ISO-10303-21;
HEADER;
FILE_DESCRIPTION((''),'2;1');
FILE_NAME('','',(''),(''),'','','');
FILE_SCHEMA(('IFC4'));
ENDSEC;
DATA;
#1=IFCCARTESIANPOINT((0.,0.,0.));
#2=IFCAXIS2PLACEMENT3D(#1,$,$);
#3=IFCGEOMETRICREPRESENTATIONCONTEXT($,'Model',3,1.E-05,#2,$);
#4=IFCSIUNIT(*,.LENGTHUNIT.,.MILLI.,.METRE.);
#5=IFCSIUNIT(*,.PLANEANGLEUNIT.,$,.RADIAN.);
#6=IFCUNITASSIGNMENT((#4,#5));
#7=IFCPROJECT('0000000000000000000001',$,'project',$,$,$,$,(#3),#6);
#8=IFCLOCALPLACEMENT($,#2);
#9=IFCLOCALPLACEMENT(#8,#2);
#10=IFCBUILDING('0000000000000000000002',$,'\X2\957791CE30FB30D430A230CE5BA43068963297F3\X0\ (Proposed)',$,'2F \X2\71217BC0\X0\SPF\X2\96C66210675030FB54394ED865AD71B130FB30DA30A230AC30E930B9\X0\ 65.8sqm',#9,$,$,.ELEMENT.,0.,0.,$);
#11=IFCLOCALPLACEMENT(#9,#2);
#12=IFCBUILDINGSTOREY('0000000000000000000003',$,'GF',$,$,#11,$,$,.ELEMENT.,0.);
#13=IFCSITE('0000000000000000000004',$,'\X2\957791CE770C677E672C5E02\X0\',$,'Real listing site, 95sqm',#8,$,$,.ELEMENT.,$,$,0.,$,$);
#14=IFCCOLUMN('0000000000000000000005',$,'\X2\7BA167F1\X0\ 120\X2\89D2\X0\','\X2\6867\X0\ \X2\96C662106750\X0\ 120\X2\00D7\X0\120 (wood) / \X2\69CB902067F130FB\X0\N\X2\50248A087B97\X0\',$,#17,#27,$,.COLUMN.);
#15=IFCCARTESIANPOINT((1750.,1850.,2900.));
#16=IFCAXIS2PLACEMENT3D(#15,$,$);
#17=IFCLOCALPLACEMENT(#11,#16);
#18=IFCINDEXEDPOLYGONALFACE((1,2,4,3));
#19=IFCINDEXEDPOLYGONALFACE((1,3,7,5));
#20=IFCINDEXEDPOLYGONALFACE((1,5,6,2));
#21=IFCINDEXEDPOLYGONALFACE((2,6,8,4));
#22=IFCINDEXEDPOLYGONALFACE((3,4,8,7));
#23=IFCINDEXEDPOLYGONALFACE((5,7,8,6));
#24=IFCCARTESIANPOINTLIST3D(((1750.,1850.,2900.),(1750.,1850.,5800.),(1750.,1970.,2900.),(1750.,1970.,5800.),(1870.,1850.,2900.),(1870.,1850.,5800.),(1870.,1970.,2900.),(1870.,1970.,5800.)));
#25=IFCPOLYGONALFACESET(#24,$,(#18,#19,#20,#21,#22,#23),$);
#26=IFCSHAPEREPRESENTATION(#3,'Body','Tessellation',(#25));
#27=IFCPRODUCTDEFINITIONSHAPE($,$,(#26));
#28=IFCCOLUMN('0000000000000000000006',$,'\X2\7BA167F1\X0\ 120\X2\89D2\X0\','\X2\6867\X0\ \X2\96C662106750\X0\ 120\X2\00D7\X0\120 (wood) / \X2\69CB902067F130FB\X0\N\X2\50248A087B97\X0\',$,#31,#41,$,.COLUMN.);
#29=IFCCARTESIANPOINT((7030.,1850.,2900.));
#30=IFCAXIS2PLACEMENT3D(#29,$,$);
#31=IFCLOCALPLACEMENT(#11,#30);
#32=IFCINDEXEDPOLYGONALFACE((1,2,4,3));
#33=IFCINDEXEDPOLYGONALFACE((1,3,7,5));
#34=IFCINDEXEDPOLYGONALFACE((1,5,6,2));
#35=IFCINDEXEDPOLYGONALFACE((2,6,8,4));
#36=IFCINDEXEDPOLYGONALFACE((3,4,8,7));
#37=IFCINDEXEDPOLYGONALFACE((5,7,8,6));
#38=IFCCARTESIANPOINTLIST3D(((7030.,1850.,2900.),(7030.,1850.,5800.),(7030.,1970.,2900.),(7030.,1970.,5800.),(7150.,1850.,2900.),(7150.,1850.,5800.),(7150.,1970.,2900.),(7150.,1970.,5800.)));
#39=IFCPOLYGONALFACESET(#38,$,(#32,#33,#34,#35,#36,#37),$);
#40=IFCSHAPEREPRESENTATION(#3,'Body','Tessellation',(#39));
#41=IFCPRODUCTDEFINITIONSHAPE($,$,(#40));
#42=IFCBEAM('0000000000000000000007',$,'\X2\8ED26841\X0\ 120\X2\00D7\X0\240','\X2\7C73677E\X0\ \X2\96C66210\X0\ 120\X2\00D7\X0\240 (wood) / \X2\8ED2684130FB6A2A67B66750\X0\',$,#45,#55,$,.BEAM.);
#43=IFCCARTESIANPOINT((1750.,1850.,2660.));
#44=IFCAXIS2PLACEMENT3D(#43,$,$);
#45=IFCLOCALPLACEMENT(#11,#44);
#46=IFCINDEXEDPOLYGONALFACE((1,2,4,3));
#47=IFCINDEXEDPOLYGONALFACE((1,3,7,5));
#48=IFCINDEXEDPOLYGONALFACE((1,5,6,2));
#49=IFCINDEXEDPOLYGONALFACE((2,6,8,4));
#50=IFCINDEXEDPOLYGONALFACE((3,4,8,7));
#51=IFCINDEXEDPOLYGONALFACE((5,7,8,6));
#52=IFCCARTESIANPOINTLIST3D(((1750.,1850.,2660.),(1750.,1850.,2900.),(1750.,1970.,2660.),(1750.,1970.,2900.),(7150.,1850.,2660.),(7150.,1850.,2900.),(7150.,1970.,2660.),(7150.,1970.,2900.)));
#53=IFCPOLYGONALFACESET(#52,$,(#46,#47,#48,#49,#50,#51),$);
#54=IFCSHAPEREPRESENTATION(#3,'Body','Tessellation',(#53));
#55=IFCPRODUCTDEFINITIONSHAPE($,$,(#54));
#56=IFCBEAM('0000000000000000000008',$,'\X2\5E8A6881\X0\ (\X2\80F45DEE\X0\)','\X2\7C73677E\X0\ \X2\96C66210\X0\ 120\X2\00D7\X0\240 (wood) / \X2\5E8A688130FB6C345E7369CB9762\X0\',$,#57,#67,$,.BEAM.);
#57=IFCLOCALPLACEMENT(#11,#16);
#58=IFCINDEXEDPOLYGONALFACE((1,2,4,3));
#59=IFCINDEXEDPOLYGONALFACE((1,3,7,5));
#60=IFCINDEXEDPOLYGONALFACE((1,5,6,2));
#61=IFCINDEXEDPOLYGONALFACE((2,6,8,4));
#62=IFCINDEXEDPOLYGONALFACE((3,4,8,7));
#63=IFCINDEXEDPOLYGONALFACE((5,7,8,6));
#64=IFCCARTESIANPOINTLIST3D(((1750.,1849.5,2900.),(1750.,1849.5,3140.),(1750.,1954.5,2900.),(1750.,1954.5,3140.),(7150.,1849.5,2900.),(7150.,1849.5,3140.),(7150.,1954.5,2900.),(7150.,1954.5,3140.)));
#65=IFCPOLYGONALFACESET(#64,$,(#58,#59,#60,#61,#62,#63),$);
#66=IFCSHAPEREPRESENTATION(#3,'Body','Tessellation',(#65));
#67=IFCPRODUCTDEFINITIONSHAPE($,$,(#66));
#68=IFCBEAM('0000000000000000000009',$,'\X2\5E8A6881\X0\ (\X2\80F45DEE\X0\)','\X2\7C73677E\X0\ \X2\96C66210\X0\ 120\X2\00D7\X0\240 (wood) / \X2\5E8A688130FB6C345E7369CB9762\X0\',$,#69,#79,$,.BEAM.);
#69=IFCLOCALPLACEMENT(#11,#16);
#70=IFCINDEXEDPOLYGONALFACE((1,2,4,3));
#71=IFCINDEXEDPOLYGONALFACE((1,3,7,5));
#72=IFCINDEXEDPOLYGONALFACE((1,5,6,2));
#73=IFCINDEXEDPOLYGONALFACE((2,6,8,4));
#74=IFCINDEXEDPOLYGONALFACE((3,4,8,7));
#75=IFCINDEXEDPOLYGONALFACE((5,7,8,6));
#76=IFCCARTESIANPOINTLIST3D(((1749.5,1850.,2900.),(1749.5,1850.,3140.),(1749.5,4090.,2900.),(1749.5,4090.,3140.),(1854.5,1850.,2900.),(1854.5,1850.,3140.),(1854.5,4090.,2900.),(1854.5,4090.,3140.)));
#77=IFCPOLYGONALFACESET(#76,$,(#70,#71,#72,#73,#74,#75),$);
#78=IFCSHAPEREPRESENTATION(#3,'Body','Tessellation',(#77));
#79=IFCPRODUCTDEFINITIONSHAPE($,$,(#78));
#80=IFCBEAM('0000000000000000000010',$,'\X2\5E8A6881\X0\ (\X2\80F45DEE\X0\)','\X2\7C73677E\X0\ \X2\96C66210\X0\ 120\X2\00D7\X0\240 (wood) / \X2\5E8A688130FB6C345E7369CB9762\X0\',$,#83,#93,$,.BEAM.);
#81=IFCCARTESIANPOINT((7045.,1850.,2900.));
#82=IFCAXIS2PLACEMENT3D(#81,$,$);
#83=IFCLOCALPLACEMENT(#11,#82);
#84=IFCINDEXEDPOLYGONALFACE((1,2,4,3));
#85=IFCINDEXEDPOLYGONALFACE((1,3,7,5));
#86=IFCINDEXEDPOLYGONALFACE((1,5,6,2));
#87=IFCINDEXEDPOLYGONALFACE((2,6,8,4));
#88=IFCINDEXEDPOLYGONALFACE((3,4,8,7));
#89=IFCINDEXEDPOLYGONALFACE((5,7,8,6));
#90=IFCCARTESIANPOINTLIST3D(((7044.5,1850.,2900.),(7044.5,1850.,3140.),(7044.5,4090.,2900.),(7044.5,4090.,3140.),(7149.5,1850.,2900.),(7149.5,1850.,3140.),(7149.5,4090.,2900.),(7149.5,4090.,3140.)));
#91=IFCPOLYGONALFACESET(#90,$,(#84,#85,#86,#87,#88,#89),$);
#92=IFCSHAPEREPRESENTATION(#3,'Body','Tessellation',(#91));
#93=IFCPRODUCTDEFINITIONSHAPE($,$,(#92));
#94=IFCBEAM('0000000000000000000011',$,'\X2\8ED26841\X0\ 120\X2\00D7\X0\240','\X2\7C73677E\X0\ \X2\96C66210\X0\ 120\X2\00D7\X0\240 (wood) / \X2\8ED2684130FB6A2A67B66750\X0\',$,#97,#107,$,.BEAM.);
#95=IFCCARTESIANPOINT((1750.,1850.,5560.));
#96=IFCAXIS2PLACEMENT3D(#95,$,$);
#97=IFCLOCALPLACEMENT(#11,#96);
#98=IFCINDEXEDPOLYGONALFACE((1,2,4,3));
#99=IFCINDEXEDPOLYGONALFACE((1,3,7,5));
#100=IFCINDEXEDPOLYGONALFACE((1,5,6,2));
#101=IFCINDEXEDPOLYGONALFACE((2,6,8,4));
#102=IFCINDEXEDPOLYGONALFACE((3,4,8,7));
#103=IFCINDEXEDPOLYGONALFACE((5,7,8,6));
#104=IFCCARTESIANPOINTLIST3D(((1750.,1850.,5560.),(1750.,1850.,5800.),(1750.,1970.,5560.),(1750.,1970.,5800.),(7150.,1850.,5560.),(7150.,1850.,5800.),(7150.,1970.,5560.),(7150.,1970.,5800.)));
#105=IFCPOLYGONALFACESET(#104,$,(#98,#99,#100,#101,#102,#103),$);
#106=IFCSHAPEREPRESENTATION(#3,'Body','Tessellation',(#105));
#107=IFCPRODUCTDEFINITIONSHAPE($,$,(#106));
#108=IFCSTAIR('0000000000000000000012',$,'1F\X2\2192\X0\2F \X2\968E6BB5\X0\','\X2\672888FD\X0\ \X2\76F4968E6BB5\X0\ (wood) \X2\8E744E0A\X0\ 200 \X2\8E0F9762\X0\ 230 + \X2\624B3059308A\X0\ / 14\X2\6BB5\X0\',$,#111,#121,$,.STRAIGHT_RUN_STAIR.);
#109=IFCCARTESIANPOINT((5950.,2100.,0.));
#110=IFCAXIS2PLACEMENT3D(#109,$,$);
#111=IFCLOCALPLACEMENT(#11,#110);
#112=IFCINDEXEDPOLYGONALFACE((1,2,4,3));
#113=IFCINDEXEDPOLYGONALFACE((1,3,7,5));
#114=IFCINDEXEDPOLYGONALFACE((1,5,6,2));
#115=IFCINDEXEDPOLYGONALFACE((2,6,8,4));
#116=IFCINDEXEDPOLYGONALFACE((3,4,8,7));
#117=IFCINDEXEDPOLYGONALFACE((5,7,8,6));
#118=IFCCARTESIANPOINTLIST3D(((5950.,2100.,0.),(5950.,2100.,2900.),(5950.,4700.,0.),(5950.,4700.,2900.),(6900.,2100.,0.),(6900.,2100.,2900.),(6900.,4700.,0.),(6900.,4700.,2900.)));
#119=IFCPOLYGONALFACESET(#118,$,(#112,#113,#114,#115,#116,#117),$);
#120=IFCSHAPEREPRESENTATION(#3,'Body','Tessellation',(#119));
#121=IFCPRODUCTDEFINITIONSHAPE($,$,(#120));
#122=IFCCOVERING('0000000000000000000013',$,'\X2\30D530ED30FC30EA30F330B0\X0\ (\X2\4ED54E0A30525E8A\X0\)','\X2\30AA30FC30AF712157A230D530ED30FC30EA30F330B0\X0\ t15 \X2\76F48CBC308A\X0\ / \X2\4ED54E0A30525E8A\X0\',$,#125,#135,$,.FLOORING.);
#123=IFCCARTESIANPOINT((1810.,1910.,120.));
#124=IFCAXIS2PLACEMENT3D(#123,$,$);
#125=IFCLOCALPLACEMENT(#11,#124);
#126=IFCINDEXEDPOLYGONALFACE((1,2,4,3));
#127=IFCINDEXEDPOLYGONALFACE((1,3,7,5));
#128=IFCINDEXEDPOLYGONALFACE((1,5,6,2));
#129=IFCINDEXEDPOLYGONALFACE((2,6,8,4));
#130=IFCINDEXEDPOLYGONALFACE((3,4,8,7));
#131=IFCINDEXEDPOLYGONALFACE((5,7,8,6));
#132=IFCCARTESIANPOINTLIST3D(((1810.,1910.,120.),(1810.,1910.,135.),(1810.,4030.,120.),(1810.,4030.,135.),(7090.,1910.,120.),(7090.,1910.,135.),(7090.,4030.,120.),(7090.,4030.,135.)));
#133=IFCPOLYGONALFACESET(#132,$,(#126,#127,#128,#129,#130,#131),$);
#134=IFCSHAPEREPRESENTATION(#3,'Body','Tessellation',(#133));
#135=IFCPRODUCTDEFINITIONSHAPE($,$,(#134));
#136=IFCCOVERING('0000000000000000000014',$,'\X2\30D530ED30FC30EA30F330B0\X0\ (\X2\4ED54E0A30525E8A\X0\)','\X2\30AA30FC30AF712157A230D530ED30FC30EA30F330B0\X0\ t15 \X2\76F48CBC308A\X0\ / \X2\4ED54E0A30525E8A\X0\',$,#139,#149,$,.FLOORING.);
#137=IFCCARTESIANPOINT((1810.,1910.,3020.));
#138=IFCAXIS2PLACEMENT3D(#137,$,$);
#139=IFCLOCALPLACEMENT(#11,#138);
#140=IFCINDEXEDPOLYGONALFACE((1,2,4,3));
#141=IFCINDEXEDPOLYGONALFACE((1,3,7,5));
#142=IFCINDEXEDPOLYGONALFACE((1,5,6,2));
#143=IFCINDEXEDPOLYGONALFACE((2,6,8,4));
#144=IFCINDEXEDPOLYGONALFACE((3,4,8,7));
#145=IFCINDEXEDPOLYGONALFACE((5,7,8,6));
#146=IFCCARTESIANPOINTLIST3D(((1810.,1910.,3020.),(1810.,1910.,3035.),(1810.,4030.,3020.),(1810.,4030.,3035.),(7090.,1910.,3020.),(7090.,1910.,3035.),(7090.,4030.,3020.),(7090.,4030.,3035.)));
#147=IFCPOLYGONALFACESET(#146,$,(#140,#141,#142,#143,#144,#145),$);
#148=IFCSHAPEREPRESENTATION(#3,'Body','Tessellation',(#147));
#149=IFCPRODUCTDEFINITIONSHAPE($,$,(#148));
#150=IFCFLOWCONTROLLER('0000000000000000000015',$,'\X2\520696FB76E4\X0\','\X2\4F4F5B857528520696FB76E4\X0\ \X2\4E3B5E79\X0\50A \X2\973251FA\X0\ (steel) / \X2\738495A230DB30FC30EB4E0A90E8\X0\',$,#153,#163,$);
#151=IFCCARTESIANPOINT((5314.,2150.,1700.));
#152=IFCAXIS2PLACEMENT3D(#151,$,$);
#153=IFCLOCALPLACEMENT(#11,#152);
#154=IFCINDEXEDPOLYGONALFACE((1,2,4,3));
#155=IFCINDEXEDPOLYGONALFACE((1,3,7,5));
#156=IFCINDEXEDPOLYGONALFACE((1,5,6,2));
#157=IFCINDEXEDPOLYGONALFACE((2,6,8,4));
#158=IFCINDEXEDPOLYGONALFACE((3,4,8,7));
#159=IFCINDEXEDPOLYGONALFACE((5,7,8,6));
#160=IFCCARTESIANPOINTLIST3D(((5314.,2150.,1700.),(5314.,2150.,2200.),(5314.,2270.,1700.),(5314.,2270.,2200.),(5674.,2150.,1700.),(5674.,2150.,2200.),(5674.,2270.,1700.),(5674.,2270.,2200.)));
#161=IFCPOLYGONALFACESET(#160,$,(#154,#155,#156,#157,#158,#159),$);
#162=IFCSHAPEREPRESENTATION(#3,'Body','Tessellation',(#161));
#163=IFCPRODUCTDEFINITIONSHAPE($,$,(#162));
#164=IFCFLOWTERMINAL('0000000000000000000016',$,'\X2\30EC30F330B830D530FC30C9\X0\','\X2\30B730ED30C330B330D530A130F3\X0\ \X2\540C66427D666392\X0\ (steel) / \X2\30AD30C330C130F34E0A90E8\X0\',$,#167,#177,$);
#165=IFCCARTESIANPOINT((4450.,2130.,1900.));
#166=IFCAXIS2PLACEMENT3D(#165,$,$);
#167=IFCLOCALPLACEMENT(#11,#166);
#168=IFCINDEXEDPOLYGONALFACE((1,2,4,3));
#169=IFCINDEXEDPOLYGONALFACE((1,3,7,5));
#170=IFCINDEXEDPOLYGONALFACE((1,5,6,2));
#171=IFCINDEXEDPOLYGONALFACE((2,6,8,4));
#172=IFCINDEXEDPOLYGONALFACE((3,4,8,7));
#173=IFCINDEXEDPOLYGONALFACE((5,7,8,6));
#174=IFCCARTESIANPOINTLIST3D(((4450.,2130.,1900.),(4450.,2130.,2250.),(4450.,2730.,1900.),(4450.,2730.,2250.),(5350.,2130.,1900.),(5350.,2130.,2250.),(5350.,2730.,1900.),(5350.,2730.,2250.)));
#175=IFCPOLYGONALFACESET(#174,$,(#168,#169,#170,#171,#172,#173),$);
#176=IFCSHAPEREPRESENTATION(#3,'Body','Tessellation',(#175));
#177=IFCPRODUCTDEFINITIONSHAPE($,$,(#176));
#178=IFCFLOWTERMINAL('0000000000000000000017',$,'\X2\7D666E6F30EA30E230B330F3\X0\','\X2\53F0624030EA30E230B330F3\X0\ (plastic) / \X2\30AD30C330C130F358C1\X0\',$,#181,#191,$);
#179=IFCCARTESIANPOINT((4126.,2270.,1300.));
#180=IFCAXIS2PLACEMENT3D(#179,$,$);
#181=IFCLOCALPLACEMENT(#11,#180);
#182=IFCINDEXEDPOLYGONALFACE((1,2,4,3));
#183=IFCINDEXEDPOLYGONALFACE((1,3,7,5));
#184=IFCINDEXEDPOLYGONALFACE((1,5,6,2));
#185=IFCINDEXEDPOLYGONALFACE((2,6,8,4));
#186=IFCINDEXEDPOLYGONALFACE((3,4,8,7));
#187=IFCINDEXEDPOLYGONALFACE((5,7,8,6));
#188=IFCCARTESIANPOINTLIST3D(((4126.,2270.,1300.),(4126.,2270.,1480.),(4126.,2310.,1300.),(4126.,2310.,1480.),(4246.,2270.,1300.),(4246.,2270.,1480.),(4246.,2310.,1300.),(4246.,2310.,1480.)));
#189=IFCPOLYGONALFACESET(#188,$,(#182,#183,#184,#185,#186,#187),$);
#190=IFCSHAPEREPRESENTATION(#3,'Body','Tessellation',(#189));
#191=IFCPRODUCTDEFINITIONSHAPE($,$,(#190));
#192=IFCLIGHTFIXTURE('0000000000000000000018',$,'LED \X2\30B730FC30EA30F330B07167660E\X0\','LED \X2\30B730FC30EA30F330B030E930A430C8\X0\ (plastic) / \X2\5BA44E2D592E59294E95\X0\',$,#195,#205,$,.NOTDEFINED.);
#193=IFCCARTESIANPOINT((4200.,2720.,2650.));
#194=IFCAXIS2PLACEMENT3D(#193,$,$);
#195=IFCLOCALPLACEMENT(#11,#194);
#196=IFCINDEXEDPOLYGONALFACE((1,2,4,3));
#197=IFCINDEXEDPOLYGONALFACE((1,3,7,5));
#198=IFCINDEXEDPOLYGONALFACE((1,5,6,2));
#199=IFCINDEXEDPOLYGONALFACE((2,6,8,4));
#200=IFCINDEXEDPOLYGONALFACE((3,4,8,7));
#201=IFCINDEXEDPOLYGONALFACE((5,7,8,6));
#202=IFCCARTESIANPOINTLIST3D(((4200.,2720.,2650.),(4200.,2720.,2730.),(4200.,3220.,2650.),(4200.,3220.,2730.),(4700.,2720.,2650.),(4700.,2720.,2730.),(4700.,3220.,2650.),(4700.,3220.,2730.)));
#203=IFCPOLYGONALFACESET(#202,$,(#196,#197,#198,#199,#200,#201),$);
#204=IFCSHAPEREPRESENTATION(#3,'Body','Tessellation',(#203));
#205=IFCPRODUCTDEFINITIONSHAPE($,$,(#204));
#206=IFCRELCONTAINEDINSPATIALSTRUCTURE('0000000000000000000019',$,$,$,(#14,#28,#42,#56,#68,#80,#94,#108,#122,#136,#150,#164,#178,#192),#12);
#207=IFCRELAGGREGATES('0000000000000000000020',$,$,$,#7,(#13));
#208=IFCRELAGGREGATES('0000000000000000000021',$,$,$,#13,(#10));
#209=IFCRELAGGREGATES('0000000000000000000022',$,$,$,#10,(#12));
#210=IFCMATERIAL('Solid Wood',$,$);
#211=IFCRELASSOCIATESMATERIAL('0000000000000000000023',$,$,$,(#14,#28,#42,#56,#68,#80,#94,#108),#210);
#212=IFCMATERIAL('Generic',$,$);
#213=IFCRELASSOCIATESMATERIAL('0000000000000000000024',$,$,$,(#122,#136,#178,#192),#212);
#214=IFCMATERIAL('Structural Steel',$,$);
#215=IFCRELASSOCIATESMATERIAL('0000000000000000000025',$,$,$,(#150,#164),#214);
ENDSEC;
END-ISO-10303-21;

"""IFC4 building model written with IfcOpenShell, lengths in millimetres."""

from ifc_helpers import new_model, si_unit, frame, frame_2d, origin, place, context, project, spatial, rectangle, extrude, material, element, save


model = new_model("IFC4")

# Units and contexts
model_context = context("Model", 3, precision=1e-05, world=origin())
ifc_project = project(units=[si_unit("LENGTHUNIT", "METRE", prefix="MILLI"), si_unit("PLANEANGLEUNIT", "RADIAN")], contexts=[model_context])

# Site, building, storey
site_placement = place(None, origin())
site = spatial("IfcSite", under=ifc_project, at=site_placement, Name="長野県松本市", ObjectType="Real listing site, 95sqm", CompositionType="ELEMENT", RefElevation=0.0)
building_placement = place(site_placement, origin())
building = spatial("IfcBuilding", under=site, at=building_placement, Name="長野・ピアノ室と防音 (Proposed)", ObjectType="2F 無節SPF集成材・吹付断熱・ペアガラス 65.8sqm", CompositionType="ELEMENT", ElevationOfRefHeight=0.0, ElevationOfTerrain=0.0)
storey_placement = place(building_placement, origin())
storey = spatial("IfcBuildingStorey", under=building, at=storey_placement, Name="GF", CompositionType="ELEMENT", Elevation=0.0)

# Columns
ifc_material_1 = material(Name="Solid Wood")
column_1_placement = place(storey_placement, frame((1750.0, 1850.0, 2900.0)))
element("IfcColumn", 1, at=column_1_placement, inside=storey, material=ifc_material_1, Name="管柱 120角", Description="桧 集成材 120×120 (wood) / 構造柱・N値計算", PredefinedType="COLUMN", context=model_context, shape_type="SweptSolid", body=[
    extrude(rectangle(XDim=120.0, YDim=120.0, at=frame_2d((60.0, 60.0))), frame((1750.0, 1850.0, 2900.0)), (0.0, 0.0, 1.0), 2900.0),
])
column_2_placement = place(storey_placement, frame((7030.0, 1850.0, 2900.0)))
element("IfcColumn", 2, at=column_2_placement, inside=storey, material=ifc_material_1, Name="管柱 120角", Description="桧 集成材 120×120 (wood) / 構造柱・N値計算", PredefinedType="COLUMN", context=model_context, shape_type="SweptSolid", body=[
    extrude(rectangle(XDim=120.0, YDim=120.0, at=frame_2d((60.0, 60.0))), frame((7030.0, 1850.0, 2900.0)), (0.0, 0.0, 1.0), 2900.0),
])

# Beams
beam_1_placement = place(storey_placement, frame((1750.0, 1850.0, 2660.0)))
element("IfcBeam", 3, at=beam_1_placement, inside=storey, material=ifc_material_1, Name="軒桁 120×240", Description="米松 集成 120×240 (wood) / 軒桁・横架材", PredefinedType="BEAM", context=model_context, shape_type="SweptSolid", body=[
    extrude(rectangle(XDim=5400.0, YDim=120.0, at=frame_2d((2700.0, 60.0))), frame((1750.0, 1850.0, 2660.0)), (0.0, 0.0, 1.0), 240.0),
])
beam_2_placement = place(storey_placement, frame((1750.0, 1850.0, 2900.0)))
element("IfcBeam", 4, at=beam_2_placement, inside=storey, material=ifc_material_1, Name="床梁 (胴差)", Description="米松 集成 120×240 (wood) / 床梁・水平構面", PredefinedType="BEAM", context=model_context, shape_type="SweptSolid", body=[
    extrude(rectangle(XDim=5400.0, YDim=105.0, at=frame_2d((2700.0, 52.0))), frame((1750.0, 1850.0, 2900.0)), (0.0, 0.0, 1.0), 240.0),
])
beam_3_placement = place(storey_placement, frame((1750.0, 1850.0, 2900.0)))
element("IfcBeam", 5, at=beam_3_placement, inside=storey, material=ifc_material_1, Name="床梁 (胴差)", Description="米松 集成 120×240 (wood) / 床梁・水平構面", PredefinedType="BEAM", context=model_context, shape_type="SweptSolid", body=[
    extrude(rectangle(XDim=105.0, YDim=2240.0, at=frame_2d((52.0, 1120.0))), frame((1750.0, 1850.0, 2900.0)), (0.0, 0.0, 1.0), 240.0),
])
beam_4_placement = place(storey_placement, frame((7045.0, 1850.0, 2900.0)))
element("IfcBeam", 6, at=beam_4_placement, inside=storey, material=ifc_material_1, Name="床梁 (胴差)", Description="米松 集成 120×240 (wood) / 床梁・水平構面", PredefinedType="BEAM", context=model_context, shape_type="SweptSolid", body=[
    extrude(rectangle(XDim=105.0, YDim=2240.0, at=frame_2d((52.0, 1120.0))), frame((7045.0, 1850.0, 2900.0)), (0.0, 0.0, 1.0), 240.0),
])
beam_5_placement = place(storey_placement, frame((1750.0, 1850.0, 5560.0)))
element("IfcBeam", 7, at=beam_5_placement, inside=storey, material=ifc_material_1, Name="軒桁 120×240", Description="米松 集成 120×240 (wood) / 軒桁・横架材", PredefinedType="BEAM", context=model_context, shape_type="SweptSolid", body=[
    extrude(rectangle(XDim=5400.0, YDim=120.0, at=frame_2d((2700.0, 60.0))), frame((1750.0, 1850.0, 5560.0)), (0.0, 0.0, 1.0), 240.0),
])

# Stair
stair_placement = place(storey_placement, frame((5950.0, 2100.0, 0.0)))
element("IfcStair", 8, at=stair_placement, inside=storey, material=ifc_material_1, Name="1F→2F 階段", Description="木製 直階段 (wood) 蹴上 200 踏面 230 + 手すり / 14段", PredefinedType="STRAIGHT_RUN_STAIR", context=model_context, shape_type="SweptSolid", body=[
    extrude(rectangle(XDim=950.0, YDim=2600.0, at=frame_2d((475.0, 1300.0))), frame((5950.0, 2100.0, 0.0)), (0.0, 0.0, 1.0), 2900.0),
])

# Coverings
ifc_material_2 = material(Name="Generic")
covering_1_placement = place(storey_placement, frame((1810.0, 1910.0, 120.0)))
element("IfcCovering", 9, at=covering_1_placement, inside=storey, material=ifc_material_2, Name="フローリング (仕上げ床)", Description="オーク無垢フローリング t15 直貼り / 仕上げ床", PredefinedType="FLOORING", context=model_context, shape_type="SweptSolid", body=[
    extrude(rectangle(XDim=5280.0, YDim=2120.0, at=frame_2d((2640.0, 1060.0))), frame((1810.0, 1910.0, 120.0)), (0.0, 0.0, 1.0), 15.0),
])
covering_2_placement = place(storey_placement, frame((1810.0, 1910.0, 3020.0)))
element("IfcCovering", 10, at=covering_2_placement, inside=storey, material=ifc_material_2, Name="フローリング (仕上げ床)", Description="オーク無垢フローリング t15 直貼り / 仕上げ床", PredefinedType="FLOORING", context=model_context, shape_type="SweptSolid", body=[
    extrude(rectangle(XDim=5280.0, YDim=2120.0, at=frame_2d((2640.0, 1060.0))), frame((1810.0, 1910.0, 3020.0)), (0.0, 0.0, 1.0), 15.0),
])

# Flow controller
ifc_material_3 = material(Name="Structural Steel")
flow_controller_placement = place(storey_placement, frame((5314.0, 2150.0, 1700.0)))
element("IfcFlowController", 11, at=flow_controller_placement, inside=storey, material=ifc_material_3, Name="分電盤", Description="住宅用分電盤 主幹50A 露出 (steel) / 玄関ホール上部", context=model_context, shape_type="SweptSolid", body=[
    extrude(rectangle(XDim=360.0, YDim=120.0, at=frame_2d((180.0, 60.0))), frame((5314.0, 2150.0, 1700.0)), (0.0, 0.0, 1.0), 500.0),
])

# Flow terminals
flow_terminal_1_placement = place(storey_placement, frame((4450.0, 2130.0, 1900.0)))
element("IfcFlowTerminal", 12, at=flow_terminal_1_placement, inside=storey, material=ifc_material_3, Name="レンジフード", Description="シロッコファン 同時給排 (steel) / キッチン上部", context=model_context, shape_type="SweptSolid", body=[
    extrude(rectangle(XDim=900.0, YDim=600.0, at=frame_2d((450.0, 300.0))), frame((4450.0, 2130.0, 1900.0)), (0.0, 0.0, 1.0), 350.0),
])
flow_terminal_2_placement = place(storey_placement, frame((4126.0, 2270.0, 1300.0)))
element("IfcFlowTerminal", 13, at=flow_terminal_2_placement, inside=storey, material=ifc_material_2, Name="給湯リモコン", Description="台所リモコン (plastic) / キッチン壁", context=model_context, shape_type="SweptSolid", body=[
    extrude(rectangle(XDim=120.0, YDim=40.0, at=frame_2d((60.0, 20.0))), frame((4126.0, 2270.0, 1300.0)), (0.0, 0.0, 1.0), 180.0),
])

# Light fixture
light_fixture_1_placement = place(storey_placement, frame((4200.0, 2720.0, 2650.0)))
element("IfcLightFixture", 14, at=light_fixture_1_placement, inside=storey, material=ifc_material_2, Name="LED シーリング照明", Description="LED シーリングライト (plastic) / 室中央天井", PredefinedType="NOTDEFINED", context=model_context, shape_type="SweptSolid", body=[
    extrude(rectangle(XDim=500.0, YDim=500.0, at=frame_2d((250.0, 250.0))), frame((4200.0, 2720.0, 2650.0)), (0.0, 0.0, 1.0), 80.0),
])

save(model, "model.ifc")
